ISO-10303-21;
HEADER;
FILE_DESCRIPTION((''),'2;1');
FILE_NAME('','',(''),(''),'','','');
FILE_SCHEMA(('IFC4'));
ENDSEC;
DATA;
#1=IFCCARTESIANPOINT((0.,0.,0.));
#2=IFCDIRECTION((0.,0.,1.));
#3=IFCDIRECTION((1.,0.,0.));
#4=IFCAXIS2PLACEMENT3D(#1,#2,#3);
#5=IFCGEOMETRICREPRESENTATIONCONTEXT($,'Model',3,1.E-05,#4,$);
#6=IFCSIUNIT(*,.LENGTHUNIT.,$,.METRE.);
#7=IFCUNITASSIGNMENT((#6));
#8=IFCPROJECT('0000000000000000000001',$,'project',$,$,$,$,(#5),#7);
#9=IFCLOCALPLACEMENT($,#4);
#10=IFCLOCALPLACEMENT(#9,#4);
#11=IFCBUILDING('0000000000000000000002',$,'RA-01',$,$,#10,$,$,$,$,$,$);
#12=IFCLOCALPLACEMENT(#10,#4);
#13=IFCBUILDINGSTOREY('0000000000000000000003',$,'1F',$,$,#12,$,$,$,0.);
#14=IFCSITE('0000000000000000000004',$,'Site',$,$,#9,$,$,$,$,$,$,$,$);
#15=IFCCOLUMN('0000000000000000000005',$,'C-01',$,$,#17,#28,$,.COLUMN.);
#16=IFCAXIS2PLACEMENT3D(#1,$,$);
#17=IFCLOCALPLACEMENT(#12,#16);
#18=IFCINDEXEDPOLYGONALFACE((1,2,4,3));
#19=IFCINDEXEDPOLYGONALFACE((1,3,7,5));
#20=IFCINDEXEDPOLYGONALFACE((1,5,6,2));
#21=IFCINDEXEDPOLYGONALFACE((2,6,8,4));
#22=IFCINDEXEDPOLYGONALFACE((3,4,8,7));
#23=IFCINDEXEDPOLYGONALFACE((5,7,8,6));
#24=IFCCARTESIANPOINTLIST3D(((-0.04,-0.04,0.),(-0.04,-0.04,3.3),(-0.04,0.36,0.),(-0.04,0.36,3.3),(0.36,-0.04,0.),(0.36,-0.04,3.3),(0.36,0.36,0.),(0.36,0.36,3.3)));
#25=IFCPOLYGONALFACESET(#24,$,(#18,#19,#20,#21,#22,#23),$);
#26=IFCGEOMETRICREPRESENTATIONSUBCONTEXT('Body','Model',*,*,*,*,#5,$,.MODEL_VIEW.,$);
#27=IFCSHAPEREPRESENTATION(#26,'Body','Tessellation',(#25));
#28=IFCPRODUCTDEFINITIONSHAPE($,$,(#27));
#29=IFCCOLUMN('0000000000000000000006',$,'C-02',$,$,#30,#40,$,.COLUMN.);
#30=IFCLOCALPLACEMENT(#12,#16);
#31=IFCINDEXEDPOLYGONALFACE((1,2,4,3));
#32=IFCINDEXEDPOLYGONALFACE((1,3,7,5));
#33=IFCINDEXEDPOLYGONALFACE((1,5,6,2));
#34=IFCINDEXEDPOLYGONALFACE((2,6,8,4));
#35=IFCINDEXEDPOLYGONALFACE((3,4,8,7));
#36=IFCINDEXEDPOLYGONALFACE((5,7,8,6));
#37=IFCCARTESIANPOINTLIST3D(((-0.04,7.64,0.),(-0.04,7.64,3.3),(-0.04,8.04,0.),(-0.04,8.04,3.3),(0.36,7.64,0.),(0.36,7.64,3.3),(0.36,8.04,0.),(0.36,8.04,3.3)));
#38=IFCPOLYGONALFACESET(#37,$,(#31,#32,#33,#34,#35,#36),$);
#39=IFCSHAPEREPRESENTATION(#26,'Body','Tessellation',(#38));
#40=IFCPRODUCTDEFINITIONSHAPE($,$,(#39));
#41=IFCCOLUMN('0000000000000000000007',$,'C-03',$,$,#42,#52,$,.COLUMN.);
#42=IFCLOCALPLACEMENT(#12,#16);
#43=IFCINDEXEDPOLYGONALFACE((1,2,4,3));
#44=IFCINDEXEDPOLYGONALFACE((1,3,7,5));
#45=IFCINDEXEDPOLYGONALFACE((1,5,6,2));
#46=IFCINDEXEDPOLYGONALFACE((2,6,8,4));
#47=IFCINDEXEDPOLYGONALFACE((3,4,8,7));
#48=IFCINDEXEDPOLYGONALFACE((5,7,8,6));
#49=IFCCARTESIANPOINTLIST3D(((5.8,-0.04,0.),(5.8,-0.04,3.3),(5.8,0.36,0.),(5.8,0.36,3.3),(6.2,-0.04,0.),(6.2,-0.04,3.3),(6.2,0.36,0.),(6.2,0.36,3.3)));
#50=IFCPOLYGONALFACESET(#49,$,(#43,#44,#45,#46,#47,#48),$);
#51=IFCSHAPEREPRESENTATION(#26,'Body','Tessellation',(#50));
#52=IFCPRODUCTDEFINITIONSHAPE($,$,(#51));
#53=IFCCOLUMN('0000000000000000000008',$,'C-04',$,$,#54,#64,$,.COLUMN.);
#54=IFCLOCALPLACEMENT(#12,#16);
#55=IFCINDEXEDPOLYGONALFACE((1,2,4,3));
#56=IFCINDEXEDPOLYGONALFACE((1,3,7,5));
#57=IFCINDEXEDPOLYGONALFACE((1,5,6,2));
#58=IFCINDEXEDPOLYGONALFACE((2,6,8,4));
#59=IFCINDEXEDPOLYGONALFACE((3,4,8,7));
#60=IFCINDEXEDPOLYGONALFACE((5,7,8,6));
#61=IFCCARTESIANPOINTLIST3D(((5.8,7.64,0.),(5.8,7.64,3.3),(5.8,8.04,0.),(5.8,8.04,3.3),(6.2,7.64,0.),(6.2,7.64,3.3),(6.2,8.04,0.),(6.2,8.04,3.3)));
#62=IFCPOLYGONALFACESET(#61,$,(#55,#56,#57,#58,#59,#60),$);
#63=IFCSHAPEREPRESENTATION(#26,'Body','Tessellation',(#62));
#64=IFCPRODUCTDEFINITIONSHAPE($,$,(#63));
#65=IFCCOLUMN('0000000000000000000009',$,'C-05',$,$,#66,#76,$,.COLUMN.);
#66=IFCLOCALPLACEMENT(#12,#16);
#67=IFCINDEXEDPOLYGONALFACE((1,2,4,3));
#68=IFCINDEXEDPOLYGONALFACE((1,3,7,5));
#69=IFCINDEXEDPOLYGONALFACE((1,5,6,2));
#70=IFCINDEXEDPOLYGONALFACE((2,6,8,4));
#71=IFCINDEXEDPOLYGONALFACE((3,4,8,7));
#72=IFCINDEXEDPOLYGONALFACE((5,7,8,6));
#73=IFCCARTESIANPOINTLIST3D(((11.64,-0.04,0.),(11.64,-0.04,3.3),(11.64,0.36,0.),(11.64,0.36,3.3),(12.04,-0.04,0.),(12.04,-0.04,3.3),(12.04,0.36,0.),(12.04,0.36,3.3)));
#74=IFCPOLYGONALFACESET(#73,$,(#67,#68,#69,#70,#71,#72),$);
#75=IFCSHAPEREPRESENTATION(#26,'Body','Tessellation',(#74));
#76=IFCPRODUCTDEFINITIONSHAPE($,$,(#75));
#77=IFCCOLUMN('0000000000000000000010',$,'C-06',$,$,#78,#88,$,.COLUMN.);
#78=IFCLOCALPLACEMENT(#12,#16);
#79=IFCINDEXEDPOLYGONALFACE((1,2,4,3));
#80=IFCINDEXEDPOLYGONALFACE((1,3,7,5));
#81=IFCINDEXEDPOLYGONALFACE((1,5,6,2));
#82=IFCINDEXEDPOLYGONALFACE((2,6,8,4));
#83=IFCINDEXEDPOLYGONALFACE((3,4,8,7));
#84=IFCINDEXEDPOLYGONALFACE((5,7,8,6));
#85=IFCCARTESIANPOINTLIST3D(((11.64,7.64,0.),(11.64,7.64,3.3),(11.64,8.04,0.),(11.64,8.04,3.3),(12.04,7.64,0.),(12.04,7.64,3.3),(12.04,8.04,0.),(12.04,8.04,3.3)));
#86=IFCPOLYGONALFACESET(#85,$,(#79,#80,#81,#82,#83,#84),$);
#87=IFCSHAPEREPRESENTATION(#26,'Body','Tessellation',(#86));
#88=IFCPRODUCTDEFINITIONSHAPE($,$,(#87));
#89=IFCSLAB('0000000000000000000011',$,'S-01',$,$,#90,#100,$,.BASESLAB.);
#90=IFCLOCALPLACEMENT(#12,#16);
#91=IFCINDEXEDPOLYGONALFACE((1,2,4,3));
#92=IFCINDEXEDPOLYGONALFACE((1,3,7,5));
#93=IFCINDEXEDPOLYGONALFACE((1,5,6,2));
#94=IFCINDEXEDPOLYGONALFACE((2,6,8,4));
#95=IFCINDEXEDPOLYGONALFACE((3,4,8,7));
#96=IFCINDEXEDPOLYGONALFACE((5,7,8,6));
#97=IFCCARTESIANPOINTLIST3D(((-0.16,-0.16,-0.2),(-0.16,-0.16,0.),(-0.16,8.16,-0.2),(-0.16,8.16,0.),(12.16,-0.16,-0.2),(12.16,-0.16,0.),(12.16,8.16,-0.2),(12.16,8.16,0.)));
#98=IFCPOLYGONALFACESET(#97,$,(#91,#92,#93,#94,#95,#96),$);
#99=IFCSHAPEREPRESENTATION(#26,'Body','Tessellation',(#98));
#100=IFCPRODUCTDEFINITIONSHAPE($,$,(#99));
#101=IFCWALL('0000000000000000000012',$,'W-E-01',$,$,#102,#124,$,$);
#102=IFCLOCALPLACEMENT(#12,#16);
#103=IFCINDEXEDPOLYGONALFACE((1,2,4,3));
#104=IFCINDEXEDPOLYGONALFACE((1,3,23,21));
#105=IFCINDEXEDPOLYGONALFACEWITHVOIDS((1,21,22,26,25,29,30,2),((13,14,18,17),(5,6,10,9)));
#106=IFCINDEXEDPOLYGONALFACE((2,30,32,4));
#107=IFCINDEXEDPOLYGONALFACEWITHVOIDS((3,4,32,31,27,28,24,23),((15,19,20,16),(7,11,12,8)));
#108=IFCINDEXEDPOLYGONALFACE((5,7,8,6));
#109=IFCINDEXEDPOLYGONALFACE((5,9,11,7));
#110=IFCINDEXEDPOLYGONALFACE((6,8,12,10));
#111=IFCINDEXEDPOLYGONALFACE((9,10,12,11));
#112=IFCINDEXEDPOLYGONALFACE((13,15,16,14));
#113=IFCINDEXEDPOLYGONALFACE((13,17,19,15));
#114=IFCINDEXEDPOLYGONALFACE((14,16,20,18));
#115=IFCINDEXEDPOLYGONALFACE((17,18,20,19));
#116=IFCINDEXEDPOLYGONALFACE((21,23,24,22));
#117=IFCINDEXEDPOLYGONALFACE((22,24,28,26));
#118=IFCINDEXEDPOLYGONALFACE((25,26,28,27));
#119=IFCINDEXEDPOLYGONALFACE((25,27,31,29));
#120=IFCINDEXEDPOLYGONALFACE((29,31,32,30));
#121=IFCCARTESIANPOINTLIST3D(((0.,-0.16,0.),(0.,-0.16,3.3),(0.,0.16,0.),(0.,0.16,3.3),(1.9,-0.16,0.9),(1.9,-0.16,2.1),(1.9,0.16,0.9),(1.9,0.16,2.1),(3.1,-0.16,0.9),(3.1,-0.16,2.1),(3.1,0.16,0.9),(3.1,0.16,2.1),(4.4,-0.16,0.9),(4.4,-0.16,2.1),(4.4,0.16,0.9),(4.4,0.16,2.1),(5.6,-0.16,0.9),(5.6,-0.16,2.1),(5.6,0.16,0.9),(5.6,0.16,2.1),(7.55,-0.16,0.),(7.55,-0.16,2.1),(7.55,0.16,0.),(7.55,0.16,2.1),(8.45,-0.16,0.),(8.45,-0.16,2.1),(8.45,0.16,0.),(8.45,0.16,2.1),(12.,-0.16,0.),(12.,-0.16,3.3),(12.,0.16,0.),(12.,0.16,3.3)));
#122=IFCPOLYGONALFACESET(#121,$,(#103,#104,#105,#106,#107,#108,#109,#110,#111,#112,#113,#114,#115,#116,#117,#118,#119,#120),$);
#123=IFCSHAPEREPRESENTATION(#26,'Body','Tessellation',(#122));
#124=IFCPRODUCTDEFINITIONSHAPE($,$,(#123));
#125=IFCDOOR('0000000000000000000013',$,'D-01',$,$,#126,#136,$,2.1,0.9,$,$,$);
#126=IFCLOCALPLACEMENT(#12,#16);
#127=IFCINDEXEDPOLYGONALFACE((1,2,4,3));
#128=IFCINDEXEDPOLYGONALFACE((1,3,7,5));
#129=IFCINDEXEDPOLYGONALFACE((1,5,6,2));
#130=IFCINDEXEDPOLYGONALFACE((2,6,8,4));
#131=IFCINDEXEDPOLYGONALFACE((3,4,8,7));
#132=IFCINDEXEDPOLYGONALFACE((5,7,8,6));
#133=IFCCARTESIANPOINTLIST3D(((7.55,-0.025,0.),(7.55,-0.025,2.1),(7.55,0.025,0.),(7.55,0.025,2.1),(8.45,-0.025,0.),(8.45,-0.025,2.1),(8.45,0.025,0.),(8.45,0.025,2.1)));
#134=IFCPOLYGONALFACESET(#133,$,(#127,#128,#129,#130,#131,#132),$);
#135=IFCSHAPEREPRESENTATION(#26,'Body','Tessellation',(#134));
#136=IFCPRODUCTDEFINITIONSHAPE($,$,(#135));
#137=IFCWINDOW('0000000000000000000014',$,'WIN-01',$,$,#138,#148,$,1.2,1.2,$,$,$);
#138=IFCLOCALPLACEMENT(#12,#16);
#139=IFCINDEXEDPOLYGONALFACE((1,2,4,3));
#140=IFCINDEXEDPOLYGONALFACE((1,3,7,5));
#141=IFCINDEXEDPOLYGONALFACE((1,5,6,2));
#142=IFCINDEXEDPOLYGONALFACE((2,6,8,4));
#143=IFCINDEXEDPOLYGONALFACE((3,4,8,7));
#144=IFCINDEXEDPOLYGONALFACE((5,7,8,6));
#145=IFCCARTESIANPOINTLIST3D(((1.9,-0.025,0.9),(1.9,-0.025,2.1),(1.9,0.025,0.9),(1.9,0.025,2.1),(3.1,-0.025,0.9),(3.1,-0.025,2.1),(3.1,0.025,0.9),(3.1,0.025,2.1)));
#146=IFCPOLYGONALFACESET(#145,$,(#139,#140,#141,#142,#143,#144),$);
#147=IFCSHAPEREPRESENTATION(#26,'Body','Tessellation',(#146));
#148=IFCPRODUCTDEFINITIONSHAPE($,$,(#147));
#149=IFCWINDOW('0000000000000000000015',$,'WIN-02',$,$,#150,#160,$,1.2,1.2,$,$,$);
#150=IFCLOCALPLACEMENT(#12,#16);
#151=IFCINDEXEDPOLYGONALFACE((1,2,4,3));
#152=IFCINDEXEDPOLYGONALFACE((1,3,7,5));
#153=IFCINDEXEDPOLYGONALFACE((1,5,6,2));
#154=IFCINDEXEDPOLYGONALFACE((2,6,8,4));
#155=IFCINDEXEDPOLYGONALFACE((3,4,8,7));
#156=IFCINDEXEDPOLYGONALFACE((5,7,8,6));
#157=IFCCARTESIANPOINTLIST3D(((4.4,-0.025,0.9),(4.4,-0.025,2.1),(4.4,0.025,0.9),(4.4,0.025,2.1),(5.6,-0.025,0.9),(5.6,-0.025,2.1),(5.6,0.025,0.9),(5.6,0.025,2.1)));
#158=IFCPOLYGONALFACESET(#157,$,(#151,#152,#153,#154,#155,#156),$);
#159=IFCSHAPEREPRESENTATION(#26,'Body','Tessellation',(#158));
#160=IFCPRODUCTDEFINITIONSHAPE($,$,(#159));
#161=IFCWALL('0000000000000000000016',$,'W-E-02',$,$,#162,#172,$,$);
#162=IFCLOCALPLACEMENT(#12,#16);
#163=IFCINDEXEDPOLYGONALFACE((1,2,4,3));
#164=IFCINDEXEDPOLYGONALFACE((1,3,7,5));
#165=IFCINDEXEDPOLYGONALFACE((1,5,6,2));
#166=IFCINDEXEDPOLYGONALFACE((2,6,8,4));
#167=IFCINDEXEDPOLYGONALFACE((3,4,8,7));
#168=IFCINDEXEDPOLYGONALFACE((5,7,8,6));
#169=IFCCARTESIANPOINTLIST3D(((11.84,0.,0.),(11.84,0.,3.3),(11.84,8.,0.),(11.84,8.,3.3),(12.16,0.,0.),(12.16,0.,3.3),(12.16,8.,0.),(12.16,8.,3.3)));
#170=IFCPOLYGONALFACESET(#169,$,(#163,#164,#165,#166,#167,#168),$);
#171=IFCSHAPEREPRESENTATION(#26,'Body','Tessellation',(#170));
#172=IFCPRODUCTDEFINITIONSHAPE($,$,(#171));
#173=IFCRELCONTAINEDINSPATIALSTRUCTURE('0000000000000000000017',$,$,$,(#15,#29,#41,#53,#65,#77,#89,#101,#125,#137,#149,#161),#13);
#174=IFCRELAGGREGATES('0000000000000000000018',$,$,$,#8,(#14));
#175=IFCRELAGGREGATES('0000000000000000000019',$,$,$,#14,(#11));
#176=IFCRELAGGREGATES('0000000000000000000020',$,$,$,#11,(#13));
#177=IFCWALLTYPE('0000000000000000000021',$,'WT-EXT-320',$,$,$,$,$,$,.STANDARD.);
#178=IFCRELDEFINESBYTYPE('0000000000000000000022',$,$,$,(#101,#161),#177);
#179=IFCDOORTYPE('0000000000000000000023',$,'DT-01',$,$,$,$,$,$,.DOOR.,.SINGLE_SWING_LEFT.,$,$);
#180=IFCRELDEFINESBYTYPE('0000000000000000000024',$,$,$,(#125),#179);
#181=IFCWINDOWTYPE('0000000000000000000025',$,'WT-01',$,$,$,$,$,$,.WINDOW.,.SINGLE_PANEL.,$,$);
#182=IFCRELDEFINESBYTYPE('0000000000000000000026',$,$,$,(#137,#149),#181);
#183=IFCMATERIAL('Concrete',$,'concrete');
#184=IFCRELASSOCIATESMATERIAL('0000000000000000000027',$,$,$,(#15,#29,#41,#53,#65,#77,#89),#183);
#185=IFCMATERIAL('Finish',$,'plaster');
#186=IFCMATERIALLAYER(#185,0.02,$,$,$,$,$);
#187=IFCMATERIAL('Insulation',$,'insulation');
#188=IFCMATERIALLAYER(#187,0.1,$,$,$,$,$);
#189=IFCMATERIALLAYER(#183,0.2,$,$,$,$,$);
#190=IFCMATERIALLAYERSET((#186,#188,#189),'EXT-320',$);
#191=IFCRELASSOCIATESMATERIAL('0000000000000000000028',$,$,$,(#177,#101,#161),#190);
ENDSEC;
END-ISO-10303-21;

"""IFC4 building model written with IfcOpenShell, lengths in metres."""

from ifc_helpers import new_model, si_unit, frame, frame_2d, origin_with_axes, origin_2d_with_axis, place, context, subcontext, project, spatial, polyline, rectangle, outline, extrude, material, layer, layer_set, layer_usage, type_object, element, fill, save


model = new_model("IFC4")

# Units and contexts
model_context = context("Model", 3, precision=1e-05, world=origin_with_axes())
body_context = subcontext(model_context, "Body", "Model", "MODEL_VIEW")
ifc_project = project(units=[si_unit("LENGTHUNIT", "METRE")], contexts=[model_context])

# Site, building, storey
site_placement = place(None, origin_with_axes())
site = spatial("IfcSite", under=ifc_project, at=site_placement, Name="Site")
building_placement = place(site_placement, origin_with_axes())
building = spatial("IfcBuilding", under=site, at=building_placement, Name="RA-01")
storey_placement = place(building_placement, origin_with_axes())
storey = spatial("IfcBuildingStorey", under=building, at=storey_placement, Name="1F", Elevation=0.0)

# Columns
ifc_material_1 = material(Name="Concrete", Category="concrete")
for number, where, z_axis, x_axis, name in (
    (1, (0.16, 0.16, 0.0), (0.0, 0.0, 1.0), (1.0, 0.0, 0.0), "C-01"),
    (2, (0.16, 7.84, 0.0), (0.0, 0.0, 1.0), (1.0, 0.0, 0.0), "C-02"),
    (3, (6.0, 0.16, 0.0), (0.0, 0.0, 1.0), (1.0, 0.0, 0.0), "C-03"),
    (4, (6.0, 7.84, 0.0), (0.0, 0.0, 1.0), (1.0, 0.0, 0.0), "C-04"),
    (5, (11.84, 0.16, 0.0), (0.0, 0.0, 1.0), (1.0, 0.0, 0.0), "C-05"),
    (6, (11.84, 7.84, 0.0), (0.0, 0.0, 1.0), (1.0, 0.0, 0.0), "C-06"),
):
    element("IfcColumn", number, at=place(storey_placement, frame(where, z_axis=z_axis, x_axis=x_axis)), inside=storey, material=ifc_material_1, Name=name, PredefinedType="COLUMN", context=body_context, shape_type="SweptSolid", body=[
        extrude(rectangle(XDim=0.4, YDim=0.4, at=origin_2d_with_axis()), origin_with_axes(), (0.0, 0.0, 1.0), 3.3),
    ])

# Slab
slab_placement = place(storey_placement, frame((0.0, 0.0, -0.2), z_axis=(0.0, 0.0, 1.0), x_axis=(1.0, 0.0, 0.0)))
element("IfcSlab", 7, at=slab_placement, inside=storey, material=ifc_material_1, Name="S-01", PredefinedType="BASESLAB", context=body_context, shape_type="SweptSolid", body=[
    extrude(outline(polyline([(-0.16, -0.16), (12.16, -0.16), (12.16, 8.16), (-0.16, 8.16), (-0.16, -0.16)])), origin_with_axes(), (0.0, 0.0, 1.0), 0.2),
])

# Wall, openings, door, windows
ifc_material_2 = material(Name="Finish", Category="plaster")
ifc_layer_1 = layer(ifc_material_2, 0.02)
ifc_material_3 = material(Name="Insulation", Category="insulation")
ifc_layer_2 = layer(ifc_material_3, 0.1)
ifc_layer_3 = layer(ifc_material_1, 0.2)
ifc_layer_set_1 = layer_set([ifc_layer_1, ifc_layer_2, ifc_layer_3], Name="EXT-320")
ifc_layer_usage_1 = layer_usage(ifc_layer_set_1, "AXIS2", "POSITIVE", -0.16)
wall_type_1 = type_object("IfcWallType", Name="WT-EXT-320", PredefinedType="STANDARD", material=ifc_layer_set_1)
wall_1_placement = place(storey_placement, origin_with_axes())
wall_1 = element("IfcWall", 8, at=wall_1_placement, inside=storey, type_object=wall_type_1, material=ifc_layer_usage_1, Name="W-E-01", context=body_context, shape_type="SweptSolid", body=[
    extrude(rectangle(XDim=12.0, YDim=0.32, at=frame_2d((6.0, 0.0), x_axis=(1.0, 0.0))), origin_with_axes(), (0.0, 0.0, 1.0), 3.3),
])
opening_1_placement = place(wall_1_placement, frame((8.0, 0.0, 0.0), z_axis=(0.0, 0.0, 1.0), x_axis=(1.0, 0.0, 0.0)))
opening_1 = element("IfcOpeningElement", 9, at=opening_1_placement, cuts=wall_1, PredefinedType="OPENING", context=body_context, shape_type="SweptSolid", body=[
    extrude(rectangle(XDim=0.9, YDim=0.42, at=origin_2d_with_axis()), origin_with_axes(), (0.0, 0.0, 1.0), 2.1),
])
opening_2_placement = place(wall_1_placement, frame((2.5, 0.0, 0.9), z_axis=(0.0, 0.0, 1.0), x_axis=(1.0, 0.0, 0.0)))
opening_2 = element("IfcOpeningElement", 10, at=opening_2_placement, cuts=wall_1, PredefinedType="OPENING", context=body_context, shape_type="SweptSolid", body=[
    extrude(rectangle(XDim=1.2, YDim=0.42, at=origin_2d_with_axis()), origin_with_axes(), (0.0, 0.0, 1.0), 1.2),
])
opening_3_placement = place(wall_1_placement, frame((5.0, 0.0, 0.9), z_axis=(0.0, 0.0, 1.0), x_axis=(1.0, 0.0, 0.0)))
opening_3 = element("IfcOpeningElement", 11, at=opening_3_placement, cuts=wall_1, PredefinedType="OPENING", context=body_context, shape_type="SweptSolid", body=[
    extrude(rectangle(XDim=1.2, YDim=0.42, at=origin_2d_with_axis()), origin_with_axes(), (0.0, 0.0, 1.0), 1.2),
])
door_type_1 = type_object("IfcDoorType", Name="DT-01", OperationType="SINGLE_SWING_LEFT", PredefinedType="DOOR")
door_1_placement = place(opening_1_placement, origin_with_axes())
door_1 = element("IfcDoor", 12, at=door_1_placement, inside=storey, type_object=door_type_1, Name="D-01", OverallHeight=2.1, OverallWidth=0.9, context=body_context, shape_type="SweptSolid", body=[
    extrude(rectangle(XDim=0.9, YDim=0.05, at=origin_2d_with_axis()), origin_with_axes(), (0.0, 0.0, 1.0), 2.1),
])
fill(opening_1, door_1)
window_type_1 = type_object("IfcWindowType", Name="WT-01", PartitioningType="SINGLE_PANEL", PredefinedType="WINDOW")
window_1_placement = place(opening_2_placement, origin_with_axes())
window_1 = element("IfcWindow", 13, at=window_1_placement, inside=storey, type_object=window_type_1, Name="WIN-01", OverallHeight=1.2, OverallWidth=1.2, context=body_context, shape_type="SweptSolid", body=[
    extrude(rectangle(XDim=1.2, YDim=0.05, at=origin_2d_with_axis()), origin_with_axes(), (0.0, 0.0, 1.0), 1.2),
])
fill(opening_2, window_1)
window_2_placement = place(opening_3_placement, origin_with_axes())
window_2 = element("IfcWindow", 14, at=window_2_placement, inside=storey, type_object=window_type_1, Name="WIN-02", OverallHeight=1.2, OverallWidth=1.2, context=body_context, shape_type="SweptSolid", body=[
    extrude(rectangle(XDim=1.2, YDim=0.05, at=origin_2d_with_axis()), origin_with_axes(), (0.0, 0.0, 1.0), 1.2),
])
fill(opening_3, window_2)

# Wall
ifc_layer_usage_2 = layer_usage(ifc_layer_set_1, "AXIS2", "POSITIVE", -0.16)
wall_2_placement = place(storey_placement, frame((12.0, 0.0, 0.0), z_axis=(0.0, 0.0, 1.0), x_axis=(0.0, 1.0, 0.0)))
element("IfcWall", 15, at=wall_2_placement, inside=storey, type_object=wall_type_1, material=ifc_layer_usage_2, Name="W-E-02", context=body_context, shape_type="SweptSolid", body=[
    extrude(rectangle(XDim=8.0, YDim=0.32, at=frame_2d((4.0, 0.0), x_axis=(1.0, 0.0))), origin_with_axes(), (0.0, 0.0, 1.0), 3.3),
])

save(model, "model.ifc")
